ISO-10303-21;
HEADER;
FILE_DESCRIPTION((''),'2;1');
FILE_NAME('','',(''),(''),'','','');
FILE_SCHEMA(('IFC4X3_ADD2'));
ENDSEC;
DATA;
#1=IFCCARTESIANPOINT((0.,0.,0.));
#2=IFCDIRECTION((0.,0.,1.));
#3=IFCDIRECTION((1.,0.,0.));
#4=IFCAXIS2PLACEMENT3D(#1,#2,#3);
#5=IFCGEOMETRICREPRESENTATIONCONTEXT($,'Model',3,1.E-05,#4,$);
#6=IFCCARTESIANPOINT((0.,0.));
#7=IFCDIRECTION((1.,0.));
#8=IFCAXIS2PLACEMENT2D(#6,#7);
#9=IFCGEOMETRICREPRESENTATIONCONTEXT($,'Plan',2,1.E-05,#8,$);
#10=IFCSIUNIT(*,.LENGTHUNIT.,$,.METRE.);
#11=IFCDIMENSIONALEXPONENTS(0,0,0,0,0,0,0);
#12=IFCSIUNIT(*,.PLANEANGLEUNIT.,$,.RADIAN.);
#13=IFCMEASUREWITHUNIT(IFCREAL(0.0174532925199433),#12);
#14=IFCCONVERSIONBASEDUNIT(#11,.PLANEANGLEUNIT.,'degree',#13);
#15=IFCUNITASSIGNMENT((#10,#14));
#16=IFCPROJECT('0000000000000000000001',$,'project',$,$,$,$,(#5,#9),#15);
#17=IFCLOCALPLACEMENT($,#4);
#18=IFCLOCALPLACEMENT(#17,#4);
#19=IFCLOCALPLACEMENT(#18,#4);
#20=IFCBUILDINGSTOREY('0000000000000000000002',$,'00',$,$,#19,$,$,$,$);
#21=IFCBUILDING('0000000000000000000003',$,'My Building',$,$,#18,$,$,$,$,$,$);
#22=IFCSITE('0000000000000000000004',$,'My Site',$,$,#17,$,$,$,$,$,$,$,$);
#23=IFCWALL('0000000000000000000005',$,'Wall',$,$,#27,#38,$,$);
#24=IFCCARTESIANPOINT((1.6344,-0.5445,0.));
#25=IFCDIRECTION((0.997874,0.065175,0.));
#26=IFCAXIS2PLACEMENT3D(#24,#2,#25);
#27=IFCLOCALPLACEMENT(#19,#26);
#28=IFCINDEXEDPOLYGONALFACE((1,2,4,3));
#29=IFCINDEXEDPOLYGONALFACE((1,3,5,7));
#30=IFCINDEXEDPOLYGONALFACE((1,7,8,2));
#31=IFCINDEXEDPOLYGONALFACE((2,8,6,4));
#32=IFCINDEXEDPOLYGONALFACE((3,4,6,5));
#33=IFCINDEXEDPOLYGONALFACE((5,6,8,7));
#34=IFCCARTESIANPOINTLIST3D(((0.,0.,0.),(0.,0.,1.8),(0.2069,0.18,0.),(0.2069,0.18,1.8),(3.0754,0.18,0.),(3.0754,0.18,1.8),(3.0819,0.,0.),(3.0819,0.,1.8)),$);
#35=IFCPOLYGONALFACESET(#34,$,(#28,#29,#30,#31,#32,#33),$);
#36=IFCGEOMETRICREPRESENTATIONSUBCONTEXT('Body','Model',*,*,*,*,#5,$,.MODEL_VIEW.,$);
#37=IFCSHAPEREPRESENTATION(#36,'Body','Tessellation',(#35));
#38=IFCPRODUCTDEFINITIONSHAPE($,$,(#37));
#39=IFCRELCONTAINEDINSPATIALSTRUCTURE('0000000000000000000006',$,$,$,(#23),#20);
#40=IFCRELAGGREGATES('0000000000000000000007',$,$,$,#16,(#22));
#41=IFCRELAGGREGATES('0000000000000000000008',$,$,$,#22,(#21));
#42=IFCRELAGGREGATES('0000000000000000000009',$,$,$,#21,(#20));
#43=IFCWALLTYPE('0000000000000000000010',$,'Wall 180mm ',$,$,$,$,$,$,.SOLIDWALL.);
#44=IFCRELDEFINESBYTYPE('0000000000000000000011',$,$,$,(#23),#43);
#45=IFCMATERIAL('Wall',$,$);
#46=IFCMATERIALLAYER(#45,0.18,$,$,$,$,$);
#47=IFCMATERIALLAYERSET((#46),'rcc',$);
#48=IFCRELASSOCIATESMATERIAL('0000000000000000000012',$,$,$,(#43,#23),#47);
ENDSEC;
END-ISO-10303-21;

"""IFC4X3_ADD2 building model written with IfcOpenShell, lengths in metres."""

from ifc_helpers import new_model, entity, si_unit, converted_unit, frame, origin_with_axes, origin_2d_with_axis, place, context, subcontext, project, spatial, indexed_curve, outline, extrude, clip, halfspace, material, layer, layer_set, layer_usage, type_object, element, save


model = new_model("IFC4X3_ADD2")

# Units and contexts
model_context = context("Model", 3, precision=1e-05, world=origin_with_axes())
plan_context = context("Plan", 2, precision=1e-05, world=origin_2d_with_axis())
body_context_1 = subcontext(model_context, "Body", "Model", "MODEL_VIEW")
ifc_project = project(units=[si_unit("LENGTHUNIT", "METRE"), converted_unit("PLANEANGLEUNIT", "degree", entity("IfcReal", 0.0174532925199433), si_unit("PLANEANGLEUNIT", "RADIAN"), dimensions=[0, 0, 0, 0, 0, 0, 0])], contexts=[model_context, plan_context])

# Site, building, storey
site_placement = place(None, origin_with_axes())
site = spatial("IfcSite", under=ifc_project, at=site_placement, Name="My Site")
building_placement = place(site_placement, origin_with_axes())
building = spatial("IfcBuilding", under=site, at=building_placement, Name="My Building")
storey_placement = place(building_placement, origin_with_axes())
storey = spatial("IfcBuildingStorey", under=building, at=storey_placement, Name="00")

# Shared definitions
ifc_material_1 = material(Name="Wall")

# Wall
ifc_layer_1 = layer(ifc_material_1, 0.18)
ifc_layer_set_1 = layer_set([ifc_layer_1], Name="rcc")
ifc_layer_usage_1 = layer_usage(ifc_layer_set_1, "AXIS2", "POSITIVE", 0.0)
wall_type_1 = type_object("IfcWallType", Name="Wall 180mm ", PredefinedType="SOLIDWALL", material=ifc_layer_set_1)
wall_1_placement = place(storey_placement, frame((1.6344, -0.5445, 0.0), z_axis=(0.0, 0.0, 1.0), x_axis=(0.997874, 0.065175, 0.0)))
element("IfcWall", 1, at=wall_1_placement, inside=storey, type_object=wall_type_1, material=ifc_layer_usage_1, Name="Wall", context=body_context_1, shape_type="Clipping", body=[
    clip(clip(extrude(outline(indexed_curve([(0.0, 0.0), (0.0, 0.18), (5.5676, 0.18), (5.5676, 0.0), (0.0, 0.0)], self_intersect=False)), origin_with_axes(), (0.0, 0.0, 1.0), 1.8), halfspace(frame((3.0819, 0.0, 0.0), z_axis=(0.999347, 0.036143, 0.0), x_axis=(0.036143, -0.999347, 0.0)), False)), halfspace(frame((0.0, 0.0, 0.0), z_axis=(-0.656326, 0.754478, 0.0), x_axis=(0.754478, 0.656326, 0.0)), False)),
])

save(model, "model.ifc")
